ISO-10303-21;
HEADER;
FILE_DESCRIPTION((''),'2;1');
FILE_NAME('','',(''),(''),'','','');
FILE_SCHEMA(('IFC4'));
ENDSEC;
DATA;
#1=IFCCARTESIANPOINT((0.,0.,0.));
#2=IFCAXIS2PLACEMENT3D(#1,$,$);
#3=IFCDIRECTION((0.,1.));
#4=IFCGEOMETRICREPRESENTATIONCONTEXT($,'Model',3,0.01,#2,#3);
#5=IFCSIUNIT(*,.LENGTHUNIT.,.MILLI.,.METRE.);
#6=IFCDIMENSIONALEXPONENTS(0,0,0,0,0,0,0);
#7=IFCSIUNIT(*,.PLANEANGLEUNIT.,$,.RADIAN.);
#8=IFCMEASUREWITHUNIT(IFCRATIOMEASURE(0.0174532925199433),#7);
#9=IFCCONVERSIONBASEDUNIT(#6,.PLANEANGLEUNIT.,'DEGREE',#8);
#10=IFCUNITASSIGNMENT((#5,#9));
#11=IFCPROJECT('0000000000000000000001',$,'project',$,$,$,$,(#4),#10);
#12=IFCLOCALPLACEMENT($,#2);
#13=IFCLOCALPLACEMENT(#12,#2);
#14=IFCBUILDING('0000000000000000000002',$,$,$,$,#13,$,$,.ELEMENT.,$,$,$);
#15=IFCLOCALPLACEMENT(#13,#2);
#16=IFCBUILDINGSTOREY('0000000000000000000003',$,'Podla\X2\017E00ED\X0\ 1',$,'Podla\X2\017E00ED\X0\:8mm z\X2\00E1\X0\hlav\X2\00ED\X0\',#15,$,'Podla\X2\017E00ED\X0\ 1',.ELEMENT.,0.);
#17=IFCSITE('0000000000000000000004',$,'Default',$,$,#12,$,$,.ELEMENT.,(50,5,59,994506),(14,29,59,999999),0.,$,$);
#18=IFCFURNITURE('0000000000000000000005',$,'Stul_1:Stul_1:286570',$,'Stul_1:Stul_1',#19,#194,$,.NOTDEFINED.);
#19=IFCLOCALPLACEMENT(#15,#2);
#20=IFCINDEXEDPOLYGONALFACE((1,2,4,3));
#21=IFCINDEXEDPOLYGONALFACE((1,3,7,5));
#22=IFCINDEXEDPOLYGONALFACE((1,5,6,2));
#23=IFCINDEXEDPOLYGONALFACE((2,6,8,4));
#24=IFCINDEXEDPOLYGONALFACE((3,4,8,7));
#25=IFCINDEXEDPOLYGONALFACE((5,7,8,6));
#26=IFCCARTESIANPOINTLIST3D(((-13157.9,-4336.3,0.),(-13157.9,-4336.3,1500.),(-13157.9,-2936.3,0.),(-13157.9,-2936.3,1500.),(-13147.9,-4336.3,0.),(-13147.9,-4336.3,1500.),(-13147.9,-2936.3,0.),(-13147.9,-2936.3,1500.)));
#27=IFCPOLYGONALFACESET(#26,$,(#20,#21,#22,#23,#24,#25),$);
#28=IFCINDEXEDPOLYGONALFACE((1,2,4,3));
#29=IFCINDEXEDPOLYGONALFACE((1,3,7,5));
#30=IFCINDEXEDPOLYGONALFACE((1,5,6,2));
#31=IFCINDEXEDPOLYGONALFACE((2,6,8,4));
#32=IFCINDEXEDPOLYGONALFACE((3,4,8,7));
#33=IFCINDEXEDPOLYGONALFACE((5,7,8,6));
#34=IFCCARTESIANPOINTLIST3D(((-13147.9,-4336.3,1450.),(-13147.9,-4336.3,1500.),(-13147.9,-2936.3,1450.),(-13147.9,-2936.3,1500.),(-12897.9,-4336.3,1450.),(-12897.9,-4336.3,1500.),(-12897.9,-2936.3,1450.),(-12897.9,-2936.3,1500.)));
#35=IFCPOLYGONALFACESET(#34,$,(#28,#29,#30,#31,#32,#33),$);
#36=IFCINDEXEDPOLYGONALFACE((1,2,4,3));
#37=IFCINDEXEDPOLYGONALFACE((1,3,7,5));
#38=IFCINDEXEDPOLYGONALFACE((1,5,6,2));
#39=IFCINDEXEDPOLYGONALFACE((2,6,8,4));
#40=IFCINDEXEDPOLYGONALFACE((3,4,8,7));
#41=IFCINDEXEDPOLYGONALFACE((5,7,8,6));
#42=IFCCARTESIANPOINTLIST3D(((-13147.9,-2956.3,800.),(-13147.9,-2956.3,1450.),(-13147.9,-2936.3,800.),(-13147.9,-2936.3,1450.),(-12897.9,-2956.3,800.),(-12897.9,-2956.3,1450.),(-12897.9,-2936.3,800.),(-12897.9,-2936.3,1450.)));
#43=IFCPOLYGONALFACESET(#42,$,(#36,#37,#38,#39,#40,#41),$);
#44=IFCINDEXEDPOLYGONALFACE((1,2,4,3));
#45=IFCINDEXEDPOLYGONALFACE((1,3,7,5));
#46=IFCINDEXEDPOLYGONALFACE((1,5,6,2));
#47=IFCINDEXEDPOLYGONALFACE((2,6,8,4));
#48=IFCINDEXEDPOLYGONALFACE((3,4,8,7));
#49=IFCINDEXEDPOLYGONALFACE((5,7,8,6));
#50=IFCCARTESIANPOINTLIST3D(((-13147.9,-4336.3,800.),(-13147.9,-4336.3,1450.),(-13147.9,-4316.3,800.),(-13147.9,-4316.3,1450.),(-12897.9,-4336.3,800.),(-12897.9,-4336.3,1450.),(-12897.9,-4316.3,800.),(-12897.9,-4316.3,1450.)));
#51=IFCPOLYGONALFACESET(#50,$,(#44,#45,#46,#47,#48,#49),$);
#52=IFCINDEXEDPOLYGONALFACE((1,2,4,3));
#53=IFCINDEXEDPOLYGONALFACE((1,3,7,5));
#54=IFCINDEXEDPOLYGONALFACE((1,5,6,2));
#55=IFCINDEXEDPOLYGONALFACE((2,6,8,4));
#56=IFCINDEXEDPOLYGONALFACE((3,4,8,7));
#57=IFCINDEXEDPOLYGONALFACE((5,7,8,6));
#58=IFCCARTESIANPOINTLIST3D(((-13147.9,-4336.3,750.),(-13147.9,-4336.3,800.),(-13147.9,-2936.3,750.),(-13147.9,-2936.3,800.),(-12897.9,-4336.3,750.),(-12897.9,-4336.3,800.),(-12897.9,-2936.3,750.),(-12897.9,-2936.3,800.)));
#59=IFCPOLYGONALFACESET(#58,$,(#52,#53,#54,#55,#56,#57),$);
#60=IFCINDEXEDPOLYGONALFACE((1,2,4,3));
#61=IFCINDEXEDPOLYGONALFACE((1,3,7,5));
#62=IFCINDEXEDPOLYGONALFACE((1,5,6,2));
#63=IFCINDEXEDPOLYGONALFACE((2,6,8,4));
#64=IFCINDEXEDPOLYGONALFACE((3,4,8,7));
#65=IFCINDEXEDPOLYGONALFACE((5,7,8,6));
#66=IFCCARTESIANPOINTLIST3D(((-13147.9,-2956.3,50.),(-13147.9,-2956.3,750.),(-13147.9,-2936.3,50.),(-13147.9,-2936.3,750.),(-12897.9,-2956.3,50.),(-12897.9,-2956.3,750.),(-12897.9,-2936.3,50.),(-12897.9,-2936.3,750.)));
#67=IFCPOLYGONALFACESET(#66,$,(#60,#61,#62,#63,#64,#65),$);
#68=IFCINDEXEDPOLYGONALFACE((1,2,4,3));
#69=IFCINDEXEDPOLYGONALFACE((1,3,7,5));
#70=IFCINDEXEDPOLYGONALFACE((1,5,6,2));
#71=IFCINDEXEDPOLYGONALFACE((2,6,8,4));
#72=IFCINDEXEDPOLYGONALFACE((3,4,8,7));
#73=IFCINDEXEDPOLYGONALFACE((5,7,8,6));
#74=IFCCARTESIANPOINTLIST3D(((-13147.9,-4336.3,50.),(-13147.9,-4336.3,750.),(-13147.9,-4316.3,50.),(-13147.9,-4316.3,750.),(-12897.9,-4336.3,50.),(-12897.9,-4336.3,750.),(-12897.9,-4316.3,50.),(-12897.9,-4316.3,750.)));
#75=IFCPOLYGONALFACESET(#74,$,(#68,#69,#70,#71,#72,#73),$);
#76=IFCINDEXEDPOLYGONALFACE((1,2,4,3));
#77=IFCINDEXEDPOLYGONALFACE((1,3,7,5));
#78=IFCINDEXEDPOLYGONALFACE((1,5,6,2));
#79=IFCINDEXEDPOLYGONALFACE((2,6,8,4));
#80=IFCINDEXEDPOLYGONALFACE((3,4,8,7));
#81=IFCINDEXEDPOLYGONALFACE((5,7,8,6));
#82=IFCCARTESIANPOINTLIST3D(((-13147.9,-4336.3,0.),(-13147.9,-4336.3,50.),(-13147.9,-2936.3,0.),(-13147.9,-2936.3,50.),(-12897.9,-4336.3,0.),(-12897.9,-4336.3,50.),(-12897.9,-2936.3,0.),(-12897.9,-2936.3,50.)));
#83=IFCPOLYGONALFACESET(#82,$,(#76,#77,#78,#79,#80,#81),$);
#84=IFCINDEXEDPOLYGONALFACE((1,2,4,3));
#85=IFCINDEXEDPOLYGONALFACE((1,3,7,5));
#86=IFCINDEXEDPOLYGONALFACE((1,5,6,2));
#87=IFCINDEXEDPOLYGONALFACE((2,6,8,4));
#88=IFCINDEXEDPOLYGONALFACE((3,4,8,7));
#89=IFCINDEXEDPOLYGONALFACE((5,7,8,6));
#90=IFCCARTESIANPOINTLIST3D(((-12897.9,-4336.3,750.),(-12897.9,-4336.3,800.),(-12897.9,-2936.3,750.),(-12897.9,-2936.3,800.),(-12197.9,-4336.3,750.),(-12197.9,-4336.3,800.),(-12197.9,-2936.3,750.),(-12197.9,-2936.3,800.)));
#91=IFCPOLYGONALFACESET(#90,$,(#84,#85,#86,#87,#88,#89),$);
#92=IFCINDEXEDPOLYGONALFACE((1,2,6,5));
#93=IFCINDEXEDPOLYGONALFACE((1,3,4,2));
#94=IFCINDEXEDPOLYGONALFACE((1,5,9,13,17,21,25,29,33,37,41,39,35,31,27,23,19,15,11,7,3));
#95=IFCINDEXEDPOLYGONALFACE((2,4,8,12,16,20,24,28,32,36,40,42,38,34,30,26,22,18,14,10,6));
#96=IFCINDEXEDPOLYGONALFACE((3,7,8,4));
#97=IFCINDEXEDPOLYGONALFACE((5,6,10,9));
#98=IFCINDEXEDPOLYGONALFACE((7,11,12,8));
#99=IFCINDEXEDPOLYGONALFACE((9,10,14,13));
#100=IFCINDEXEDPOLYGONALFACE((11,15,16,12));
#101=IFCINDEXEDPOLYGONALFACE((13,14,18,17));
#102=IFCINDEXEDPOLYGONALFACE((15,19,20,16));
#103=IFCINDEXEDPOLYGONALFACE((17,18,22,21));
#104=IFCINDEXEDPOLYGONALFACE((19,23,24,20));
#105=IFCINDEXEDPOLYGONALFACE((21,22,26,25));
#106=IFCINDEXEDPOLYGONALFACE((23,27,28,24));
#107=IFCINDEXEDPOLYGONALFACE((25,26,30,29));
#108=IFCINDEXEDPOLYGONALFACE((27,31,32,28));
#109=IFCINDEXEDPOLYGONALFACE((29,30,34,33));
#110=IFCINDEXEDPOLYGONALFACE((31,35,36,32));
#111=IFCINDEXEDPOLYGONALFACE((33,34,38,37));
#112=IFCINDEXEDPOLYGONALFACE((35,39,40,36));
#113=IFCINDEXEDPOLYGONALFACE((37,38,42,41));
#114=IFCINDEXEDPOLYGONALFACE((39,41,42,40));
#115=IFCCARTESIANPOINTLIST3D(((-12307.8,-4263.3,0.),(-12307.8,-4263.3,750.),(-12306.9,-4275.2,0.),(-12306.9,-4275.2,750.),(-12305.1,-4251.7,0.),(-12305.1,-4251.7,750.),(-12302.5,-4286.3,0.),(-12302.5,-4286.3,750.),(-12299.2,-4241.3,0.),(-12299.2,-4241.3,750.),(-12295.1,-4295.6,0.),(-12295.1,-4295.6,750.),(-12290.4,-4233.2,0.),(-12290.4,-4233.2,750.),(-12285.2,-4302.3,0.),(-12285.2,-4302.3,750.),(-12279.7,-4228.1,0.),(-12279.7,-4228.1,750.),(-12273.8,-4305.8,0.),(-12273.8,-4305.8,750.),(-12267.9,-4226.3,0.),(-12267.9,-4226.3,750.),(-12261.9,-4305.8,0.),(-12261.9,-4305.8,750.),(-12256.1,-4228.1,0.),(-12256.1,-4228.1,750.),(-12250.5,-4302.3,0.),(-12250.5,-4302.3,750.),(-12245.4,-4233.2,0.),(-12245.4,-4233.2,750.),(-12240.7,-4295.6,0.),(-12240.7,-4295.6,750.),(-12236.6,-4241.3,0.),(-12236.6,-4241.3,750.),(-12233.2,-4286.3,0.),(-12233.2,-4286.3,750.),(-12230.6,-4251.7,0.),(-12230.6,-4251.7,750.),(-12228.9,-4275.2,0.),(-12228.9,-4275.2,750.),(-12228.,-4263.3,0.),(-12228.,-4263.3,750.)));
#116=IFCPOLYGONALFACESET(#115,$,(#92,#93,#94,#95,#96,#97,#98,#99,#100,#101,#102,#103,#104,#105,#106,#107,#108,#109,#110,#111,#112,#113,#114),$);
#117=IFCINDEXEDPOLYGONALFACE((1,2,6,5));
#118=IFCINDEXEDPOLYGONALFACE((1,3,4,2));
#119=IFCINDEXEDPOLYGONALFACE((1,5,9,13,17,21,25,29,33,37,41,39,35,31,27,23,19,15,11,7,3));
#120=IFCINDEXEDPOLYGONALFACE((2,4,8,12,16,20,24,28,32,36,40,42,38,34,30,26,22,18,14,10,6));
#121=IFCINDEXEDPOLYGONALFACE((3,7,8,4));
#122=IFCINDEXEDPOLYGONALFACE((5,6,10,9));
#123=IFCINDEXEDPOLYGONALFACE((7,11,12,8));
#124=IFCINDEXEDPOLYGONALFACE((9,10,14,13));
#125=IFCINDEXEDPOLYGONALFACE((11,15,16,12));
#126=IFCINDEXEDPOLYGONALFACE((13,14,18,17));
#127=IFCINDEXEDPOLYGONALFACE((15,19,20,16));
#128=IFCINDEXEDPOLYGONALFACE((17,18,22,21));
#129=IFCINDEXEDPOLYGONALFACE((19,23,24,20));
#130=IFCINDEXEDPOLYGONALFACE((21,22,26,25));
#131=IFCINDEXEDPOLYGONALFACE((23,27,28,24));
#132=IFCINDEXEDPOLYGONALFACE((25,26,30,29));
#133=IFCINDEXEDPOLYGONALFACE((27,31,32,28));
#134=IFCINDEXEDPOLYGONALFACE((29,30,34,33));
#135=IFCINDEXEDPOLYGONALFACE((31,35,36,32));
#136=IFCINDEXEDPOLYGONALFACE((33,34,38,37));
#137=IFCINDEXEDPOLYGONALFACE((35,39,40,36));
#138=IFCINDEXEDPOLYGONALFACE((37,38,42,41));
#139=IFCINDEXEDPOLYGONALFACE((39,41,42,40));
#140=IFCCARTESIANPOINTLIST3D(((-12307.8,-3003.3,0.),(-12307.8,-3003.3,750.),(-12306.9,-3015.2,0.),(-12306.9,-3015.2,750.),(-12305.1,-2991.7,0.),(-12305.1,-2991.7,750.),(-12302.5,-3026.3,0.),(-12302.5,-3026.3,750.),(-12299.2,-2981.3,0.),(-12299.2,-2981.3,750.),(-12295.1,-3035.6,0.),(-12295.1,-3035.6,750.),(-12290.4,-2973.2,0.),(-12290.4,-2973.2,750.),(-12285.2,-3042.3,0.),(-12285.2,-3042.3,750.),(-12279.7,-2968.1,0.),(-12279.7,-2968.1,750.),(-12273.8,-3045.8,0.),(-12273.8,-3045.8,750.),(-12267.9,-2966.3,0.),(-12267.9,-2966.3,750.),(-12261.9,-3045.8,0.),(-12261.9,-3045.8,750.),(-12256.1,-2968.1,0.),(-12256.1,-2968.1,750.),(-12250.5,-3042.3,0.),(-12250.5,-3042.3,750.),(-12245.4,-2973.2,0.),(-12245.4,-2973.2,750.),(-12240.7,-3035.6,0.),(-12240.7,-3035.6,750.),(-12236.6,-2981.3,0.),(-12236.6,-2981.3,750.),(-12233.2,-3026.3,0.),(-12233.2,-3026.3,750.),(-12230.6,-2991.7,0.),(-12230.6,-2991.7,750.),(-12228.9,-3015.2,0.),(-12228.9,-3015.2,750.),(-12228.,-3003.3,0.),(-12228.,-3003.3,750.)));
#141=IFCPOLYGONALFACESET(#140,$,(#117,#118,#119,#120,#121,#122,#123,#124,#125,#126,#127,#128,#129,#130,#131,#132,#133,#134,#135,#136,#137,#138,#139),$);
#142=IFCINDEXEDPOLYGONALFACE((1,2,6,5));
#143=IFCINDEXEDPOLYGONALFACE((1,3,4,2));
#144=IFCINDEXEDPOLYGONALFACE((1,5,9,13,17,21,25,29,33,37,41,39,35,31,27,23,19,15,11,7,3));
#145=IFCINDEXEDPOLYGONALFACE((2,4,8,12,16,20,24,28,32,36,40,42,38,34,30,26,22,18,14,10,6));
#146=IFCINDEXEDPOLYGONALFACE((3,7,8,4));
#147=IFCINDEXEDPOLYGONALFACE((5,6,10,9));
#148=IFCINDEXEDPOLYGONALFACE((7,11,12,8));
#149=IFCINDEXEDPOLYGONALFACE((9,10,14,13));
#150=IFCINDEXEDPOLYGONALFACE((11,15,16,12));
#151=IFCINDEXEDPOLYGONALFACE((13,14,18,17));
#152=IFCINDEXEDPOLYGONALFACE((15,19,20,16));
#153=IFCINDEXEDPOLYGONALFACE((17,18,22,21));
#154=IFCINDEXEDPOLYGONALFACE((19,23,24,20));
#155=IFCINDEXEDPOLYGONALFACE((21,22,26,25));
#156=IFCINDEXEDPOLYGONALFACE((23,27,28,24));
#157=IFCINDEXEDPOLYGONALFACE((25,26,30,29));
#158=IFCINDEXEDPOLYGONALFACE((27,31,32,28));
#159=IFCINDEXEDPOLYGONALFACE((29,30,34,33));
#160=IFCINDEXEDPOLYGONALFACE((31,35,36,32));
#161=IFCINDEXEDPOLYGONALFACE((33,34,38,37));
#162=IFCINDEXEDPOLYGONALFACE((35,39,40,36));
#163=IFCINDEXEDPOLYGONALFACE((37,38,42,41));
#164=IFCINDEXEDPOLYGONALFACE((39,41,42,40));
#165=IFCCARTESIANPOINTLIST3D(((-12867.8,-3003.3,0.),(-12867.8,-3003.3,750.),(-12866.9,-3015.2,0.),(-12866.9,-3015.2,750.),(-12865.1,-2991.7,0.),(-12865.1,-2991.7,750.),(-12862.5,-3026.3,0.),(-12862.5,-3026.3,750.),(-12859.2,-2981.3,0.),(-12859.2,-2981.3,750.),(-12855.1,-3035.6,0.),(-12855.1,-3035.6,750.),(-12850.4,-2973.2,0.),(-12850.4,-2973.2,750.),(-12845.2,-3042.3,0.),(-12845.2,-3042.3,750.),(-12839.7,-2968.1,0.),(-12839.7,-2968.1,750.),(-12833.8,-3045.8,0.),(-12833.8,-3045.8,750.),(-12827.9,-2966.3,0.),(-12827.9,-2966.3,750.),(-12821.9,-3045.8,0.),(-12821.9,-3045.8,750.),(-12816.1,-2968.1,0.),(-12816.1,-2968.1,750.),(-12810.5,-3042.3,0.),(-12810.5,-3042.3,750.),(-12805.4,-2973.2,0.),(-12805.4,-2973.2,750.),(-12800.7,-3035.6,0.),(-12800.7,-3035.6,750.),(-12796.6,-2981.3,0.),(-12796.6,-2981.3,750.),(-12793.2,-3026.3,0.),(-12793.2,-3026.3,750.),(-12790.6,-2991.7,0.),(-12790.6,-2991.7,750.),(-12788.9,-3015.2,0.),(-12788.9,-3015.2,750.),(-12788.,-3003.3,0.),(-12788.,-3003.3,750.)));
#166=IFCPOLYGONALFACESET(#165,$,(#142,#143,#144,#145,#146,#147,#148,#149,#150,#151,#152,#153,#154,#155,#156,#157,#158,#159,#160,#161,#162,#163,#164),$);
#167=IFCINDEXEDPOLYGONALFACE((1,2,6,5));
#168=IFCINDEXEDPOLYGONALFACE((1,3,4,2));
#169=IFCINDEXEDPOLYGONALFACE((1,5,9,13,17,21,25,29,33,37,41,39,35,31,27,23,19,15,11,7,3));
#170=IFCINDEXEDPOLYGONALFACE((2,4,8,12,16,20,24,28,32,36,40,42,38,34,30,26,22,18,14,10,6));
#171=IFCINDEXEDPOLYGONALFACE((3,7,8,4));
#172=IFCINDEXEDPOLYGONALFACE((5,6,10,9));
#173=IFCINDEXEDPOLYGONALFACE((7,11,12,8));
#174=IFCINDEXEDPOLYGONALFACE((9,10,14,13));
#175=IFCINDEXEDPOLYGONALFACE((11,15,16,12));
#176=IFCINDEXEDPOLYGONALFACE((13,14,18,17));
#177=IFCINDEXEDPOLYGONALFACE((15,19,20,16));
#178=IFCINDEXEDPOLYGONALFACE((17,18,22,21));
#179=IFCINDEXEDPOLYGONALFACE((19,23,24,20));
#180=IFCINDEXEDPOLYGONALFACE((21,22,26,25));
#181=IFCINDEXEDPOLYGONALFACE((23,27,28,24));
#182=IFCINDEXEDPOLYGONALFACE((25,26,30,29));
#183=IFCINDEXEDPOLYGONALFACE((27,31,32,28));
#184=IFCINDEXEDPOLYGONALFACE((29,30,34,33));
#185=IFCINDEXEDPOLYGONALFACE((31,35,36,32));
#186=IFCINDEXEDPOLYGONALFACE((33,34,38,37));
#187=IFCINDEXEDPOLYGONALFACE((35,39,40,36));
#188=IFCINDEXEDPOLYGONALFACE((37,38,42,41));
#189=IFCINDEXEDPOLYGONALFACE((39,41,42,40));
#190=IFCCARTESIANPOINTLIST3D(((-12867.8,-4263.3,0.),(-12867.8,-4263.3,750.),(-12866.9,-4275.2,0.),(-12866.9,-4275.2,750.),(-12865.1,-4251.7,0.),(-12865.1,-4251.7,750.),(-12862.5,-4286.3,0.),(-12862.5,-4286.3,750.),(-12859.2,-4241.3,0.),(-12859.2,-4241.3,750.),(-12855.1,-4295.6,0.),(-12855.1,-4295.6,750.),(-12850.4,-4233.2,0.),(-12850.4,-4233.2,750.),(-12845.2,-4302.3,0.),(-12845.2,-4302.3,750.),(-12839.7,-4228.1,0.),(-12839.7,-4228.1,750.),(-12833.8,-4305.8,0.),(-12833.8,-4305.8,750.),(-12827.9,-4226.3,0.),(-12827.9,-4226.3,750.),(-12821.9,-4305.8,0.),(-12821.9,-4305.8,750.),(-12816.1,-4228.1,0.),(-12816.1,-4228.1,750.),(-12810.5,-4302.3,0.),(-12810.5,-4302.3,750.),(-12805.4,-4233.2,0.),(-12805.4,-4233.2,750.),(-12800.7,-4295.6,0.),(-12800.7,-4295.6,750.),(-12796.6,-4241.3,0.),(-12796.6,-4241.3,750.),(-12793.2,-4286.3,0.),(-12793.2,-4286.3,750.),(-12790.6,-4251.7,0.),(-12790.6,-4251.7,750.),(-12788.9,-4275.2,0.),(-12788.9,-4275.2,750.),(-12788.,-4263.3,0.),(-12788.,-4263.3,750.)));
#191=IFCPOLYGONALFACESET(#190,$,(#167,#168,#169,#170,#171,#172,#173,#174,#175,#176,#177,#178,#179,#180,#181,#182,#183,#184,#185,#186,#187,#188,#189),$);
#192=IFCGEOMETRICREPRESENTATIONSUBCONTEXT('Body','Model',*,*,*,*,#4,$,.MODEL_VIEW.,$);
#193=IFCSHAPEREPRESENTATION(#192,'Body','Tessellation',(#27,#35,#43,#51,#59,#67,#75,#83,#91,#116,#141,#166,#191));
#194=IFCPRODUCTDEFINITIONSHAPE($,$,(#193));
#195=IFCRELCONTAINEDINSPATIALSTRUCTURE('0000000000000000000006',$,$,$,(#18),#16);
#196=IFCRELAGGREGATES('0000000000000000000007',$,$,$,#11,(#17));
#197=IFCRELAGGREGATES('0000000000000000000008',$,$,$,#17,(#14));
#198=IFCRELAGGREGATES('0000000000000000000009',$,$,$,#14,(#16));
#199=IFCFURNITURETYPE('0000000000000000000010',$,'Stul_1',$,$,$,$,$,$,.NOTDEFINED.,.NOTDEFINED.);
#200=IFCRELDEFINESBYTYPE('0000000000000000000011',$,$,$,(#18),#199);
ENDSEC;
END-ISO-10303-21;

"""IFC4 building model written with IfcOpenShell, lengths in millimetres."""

from ifc_helpers import new_model, entity, si_unit, converted_unit, direction, frame, frame_2d, origin, origin_2d_with_axis, place, context, subcontext, project, spatial, rectangle, circle, extrude, source, transform, mapped, type_object, type_shapes, element, save


model = new_model("IFC4")

# Units and contexts
model_context = context("Model", 3, precision=0.01, world=origin(), true_north=direction((0.0, 1.0)))
body_context = subcontext(model_context, "Body", "Model", "MODEL_VIEW")
ifc_project = project(units=[si_unit("LENGTHUNIT", "METRE", prefix="MILLI"), converted_unit("PLANEANGLEUNIT", "DEGREE", entity("IfcRatioMeasure", 0.0174532925199433), si_unit("PLANEANGLEUNIT", "RADIAN"), dimensions=[0, 0, 0, 0, 0, 0, 0])], contexts=[model_context])

# Site, building, storey
site_placement = place(None, origin())
site = spatial("IfcSite", under=ifc_project, at=site_placement, Name="Default", CompositionType="ELEMENT", RefLatitude=(50, 5, 59, 994506), RefLongitude=(14, 29, 59, 999999), RefElevation=0.0)
building_placement = place(site_placement, origin())
building = spatial("IfcBuilding", under=site, at=building_placement, CompositionType="ELEMENT")
storey_placement = place(building_placement, origin())
storey = spatial("IfcBuildingStorey", under=building, at=storey_placement, Name="Podlaží 1", ObjectType="Podlaží:8mm záhlaví", LongName="Podlaží 1", CompositionType="ELEMENT", Elevation=0.0)

# Furniture
furniture_type = type_object("IfcFurnitureType", Name="Stul_1", AssemblyPlace="NOTDEFINED", PredefinedType="NOTDEFINED")
shared_shape_1 = source(origin(), body_context, "Body", "SweptSolid", [
    extrude(rectangle(XDim=1400.0, YDim=10.0, at=origin_2d_with_axis()), frame((0.0, 605.0, 0.0), z_axis=(0.0, 0.0, 1.0), x_axis=(-1.0, 0.0, 0.0)), (0.0, 0.0, 1.0), 1500.0),
    extrude(rectangle(XDim=1400.0, YDim=250.0, at=frame_2d((0.0, 0.0), x_axis=(1.0, 0.0))), frame((0.0, 475.0, 1450.0), z_axis=(0.0, 0.0, 1.0), x_axis=(-1.0, 0.0, 0.0)), (0.0, 0.0, 1.0), 50.0),
    extrude(rectangle(XDim=20.0, YDim=250.0, at=origin_2d_with_axis()), frame((690.0, 475.0, 800.0), z_axis=(0.0, 0.0, 1.0), x_axis=(-1.0, 0.0, 0.0)), (0.0, 0.0, 1.0), 650.0),
    extrude(rectangle(XDim=20.0, YDim=250.0, at=frame_2d((0.0, 0.0), x_axis=(1.0, 0.0))), frame((-690.0, 475.0, 800.0), z_axis=(0.0, 0.0, 1.0), x_axis=(-1.0, 0.0, 0.0)), (0.0, 0.0, 1.0), 650.0),
    extrude(rectangle(XDim=1400.0, YDim=250.0, at=origin_2d_with_axis()), frame((0.0, 475.0, 750.0), z_axis=(0.0, 0.0, 1.0), x_axis=(-1.0, 0.0, 0.0)), (0.0, 0.0, 1.0), 50.0),
    extrude(rectangle(XDim=20.0, YDim=250.0, at=origin_2d_with_axis()), frame((690.0, 475.0, 50.0), z_axis=(0.0, 0.0, 1.0), x_axis=(-1.0, 0.0, 0.0)), (0.0, 0.0, 1.0), 700.0),
    extrude(rectangle(XDim=20.0, YDim=250.0, at=frame_2d((0.0, 0.0), x_axis=(1.0, 0.0))), frame((-690.0, 475.0, 50.0), z_axis=(0.0, 0.0, 1.0), x_axis=(-1.0, 0.0, 0.0)), (0.0, 0.0, 1.0), 700.0),
    extrude(rectangle(XDim=1400.0, YDim=250.0, at=origin_2d_with_axis()), frame((0.0, 475.0, 0.0), z_axis=(0.0, 0.0, 1.0), x_axis=(-1.0, 0.0, 0.0)), (0.0, 0.0, 1.0), 50.0),
    extrude(rectangle(XDim=1400.0, YDim=700.0, at=origin_2d_with_axis()), frame((0.0, 0.0, 750.0), z_axis=(0.0, 0.0, 1.0), x_axis=(-1.0, 0.0, 0.0)), (0.0, 0.0, 1.0), 50.0),
    extrude(circle(Radius=40.0, at=frame_2d((0.0, 0.0), x_axis=(1.0, 0.0))), frame((-630.0, -280.0, 0.0)), (0.0, 0.0, 1.0), 750.0),
    extrude(circle(Radius=40.0, at=frame_2d((0.0, 0.0), x_axis=(1.0, 0.0))), frame((630.0, -280.0, 0.0)), (0.0, 0.0, 1.0), 750.0),
    extrude(circle(Radius=40.0, at=frame_2d((0.0, 0.0), x_axis=(1.0, 0.0))), frame((630.0, 280.0, 0.0)), (0.0, 0.0, 1.0), 750.0),
    extrude(circle(Radius=40.0, at=frame_2d((0.0, 0.0), x_axis=(1.0, 0.0))), frame((-630.0, 280.0, 0.0)), (0.0, 0.0, 1.0), 750.0),
])
type_shapes(furniture_type, [shared_shape_1])
for number, where, z_axis, x_axis, name in (
    (1, (-12547.9, -3636.3, 0.0), (0.0, 0.0, 1.0), (0.0, 1.0, 0.0), "Stul_1:Stul_1:286570"),
):
    element("IfcFurniture", number, at=place(storey_placement, frame(where, z_axis=z_axis, x_axis=x_axis)), inside=storey, type_object=furniture_type, Name=name, ObjectType="Stul_1:Stul_1", PredefinedType="NOTDEFINED", context=body_context, shape_type="MappedRepresentation", body=[
        mapped(shared_shape_1, transform((0.0, 0.0, 0.0), scale=1.0)),
    ])

save(model, "model.ifc")
